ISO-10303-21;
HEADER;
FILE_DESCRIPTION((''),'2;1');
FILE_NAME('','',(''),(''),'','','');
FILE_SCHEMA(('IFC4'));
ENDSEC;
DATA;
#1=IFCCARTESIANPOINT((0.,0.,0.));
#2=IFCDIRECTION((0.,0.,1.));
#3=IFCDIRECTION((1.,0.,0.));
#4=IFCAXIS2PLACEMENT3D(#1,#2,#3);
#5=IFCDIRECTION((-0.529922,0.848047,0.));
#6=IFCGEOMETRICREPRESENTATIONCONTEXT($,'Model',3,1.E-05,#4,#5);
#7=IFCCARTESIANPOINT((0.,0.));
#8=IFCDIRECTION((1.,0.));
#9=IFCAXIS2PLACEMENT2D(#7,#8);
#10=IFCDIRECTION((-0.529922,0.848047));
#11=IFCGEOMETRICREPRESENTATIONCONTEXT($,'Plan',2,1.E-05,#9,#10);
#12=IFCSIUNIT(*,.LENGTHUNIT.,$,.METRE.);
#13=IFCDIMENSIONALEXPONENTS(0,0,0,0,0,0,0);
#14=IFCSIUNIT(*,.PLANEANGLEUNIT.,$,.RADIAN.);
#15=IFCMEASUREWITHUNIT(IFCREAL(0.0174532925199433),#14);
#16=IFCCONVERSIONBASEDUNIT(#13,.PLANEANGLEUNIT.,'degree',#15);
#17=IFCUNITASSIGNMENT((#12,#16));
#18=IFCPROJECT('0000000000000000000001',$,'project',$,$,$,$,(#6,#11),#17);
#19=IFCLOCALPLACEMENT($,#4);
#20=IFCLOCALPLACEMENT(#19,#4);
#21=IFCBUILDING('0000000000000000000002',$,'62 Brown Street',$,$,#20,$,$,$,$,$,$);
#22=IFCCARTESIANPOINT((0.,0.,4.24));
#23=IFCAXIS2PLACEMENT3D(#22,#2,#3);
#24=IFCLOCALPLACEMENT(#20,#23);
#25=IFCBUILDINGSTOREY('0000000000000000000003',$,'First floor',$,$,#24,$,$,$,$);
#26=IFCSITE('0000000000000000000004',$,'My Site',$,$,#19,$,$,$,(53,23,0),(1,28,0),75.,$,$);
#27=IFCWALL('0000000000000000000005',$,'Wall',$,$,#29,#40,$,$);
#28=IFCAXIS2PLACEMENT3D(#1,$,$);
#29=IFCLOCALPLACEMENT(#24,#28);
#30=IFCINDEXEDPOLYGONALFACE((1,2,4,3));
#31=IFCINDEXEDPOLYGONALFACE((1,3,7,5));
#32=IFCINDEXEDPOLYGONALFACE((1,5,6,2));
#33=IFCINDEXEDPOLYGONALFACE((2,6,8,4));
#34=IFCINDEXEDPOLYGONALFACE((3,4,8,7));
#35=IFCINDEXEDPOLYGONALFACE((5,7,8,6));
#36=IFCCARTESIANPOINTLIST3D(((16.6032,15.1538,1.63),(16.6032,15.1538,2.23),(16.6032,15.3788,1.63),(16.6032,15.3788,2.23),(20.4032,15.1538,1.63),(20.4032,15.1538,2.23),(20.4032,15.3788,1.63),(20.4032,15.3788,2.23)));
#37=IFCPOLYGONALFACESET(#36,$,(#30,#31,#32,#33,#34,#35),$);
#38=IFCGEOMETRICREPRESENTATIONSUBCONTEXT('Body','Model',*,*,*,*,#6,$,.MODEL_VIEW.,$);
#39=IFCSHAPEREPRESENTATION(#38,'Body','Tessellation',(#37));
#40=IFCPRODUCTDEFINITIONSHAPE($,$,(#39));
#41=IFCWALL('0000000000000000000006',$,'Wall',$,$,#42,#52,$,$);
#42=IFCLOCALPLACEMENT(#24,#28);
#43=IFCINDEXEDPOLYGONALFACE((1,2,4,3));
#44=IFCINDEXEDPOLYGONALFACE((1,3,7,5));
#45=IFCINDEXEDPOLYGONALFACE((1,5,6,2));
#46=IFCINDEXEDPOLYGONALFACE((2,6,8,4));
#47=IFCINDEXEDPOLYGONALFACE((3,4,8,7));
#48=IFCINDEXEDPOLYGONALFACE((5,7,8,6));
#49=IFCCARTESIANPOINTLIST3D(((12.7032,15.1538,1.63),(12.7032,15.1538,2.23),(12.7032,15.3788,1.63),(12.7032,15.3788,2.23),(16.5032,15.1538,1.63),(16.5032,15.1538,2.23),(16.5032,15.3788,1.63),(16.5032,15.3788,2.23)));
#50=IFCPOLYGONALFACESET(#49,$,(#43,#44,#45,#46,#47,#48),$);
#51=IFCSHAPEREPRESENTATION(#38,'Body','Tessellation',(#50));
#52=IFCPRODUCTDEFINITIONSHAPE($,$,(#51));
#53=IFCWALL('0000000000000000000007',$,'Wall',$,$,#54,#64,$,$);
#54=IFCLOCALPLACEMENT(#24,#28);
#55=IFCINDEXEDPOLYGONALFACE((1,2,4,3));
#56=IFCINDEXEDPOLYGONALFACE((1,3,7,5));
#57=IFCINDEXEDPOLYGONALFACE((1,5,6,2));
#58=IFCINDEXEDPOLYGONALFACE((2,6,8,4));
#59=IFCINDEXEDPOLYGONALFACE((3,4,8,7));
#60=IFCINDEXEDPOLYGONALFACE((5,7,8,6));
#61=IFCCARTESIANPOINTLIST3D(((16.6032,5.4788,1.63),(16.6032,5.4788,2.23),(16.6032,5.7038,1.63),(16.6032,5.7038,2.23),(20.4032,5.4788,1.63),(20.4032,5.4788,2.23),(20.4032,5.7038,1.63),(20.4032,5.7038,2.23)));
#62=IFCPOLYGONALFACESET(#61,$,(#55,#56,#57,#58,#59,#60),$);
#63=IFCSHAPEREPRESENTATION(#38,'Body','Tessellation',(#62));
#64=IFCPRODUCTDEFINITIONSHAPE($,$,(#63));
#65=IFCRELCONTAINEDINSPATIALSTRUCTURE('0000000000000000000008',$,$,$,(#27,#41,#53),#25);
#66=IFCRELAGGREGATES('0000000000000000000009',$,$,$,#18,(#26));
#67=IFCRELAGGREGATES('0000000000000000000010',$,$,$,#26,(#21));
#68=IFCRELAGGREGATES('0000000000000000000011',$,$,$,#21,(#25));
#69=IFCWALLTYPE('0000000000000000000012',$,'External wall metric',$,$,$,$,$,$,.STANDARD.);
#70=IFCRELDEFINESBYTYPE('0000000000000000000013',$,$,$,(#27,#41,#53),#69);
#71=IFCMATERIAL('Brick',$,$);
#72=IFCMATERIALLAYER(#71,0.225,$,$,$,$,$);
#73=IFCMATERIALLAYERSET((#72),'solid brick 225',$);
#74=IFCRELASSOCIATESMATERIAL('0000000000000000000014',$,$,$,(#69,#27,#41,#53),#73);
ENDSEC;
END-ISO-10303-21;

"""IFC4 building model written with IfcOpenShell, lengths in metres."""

from ifc_helpers import new_model, entity, si_unit, converted_unit, direction, frame, origin_with_axes, origin_2d_with_axis, place, context, subcontext, project, spatial, indexed_curve, outline, extrude, material, layer, layer_set, layer_usage, type_object, element, save


model = new_model("IFC4")

# Units and contexts
model_context = context("Model", 3, precision=1e-05, world=origin_with_axes(), true_north=direction((-0.529922, 0.848047, 0.0)))
plan_context = context("Plan", 2, precision=1e-05, world=origin_2d_with_axis(), true_north=direction((-0.529922, 0.848047)))
body_context = subcontext(model_context, "Body", "Model", "MODEL_VIEW")
ifc_project = project(units=[si_unit("LENGTHUNIT", "METRE"), converted_unit("PLANEANGLEUNIT", "degree", entity("IfcReal", 0.0174532925199433), si_unit("PLANEANGLEUNIT", "RADIAN"), dimensions=[0, 0, 0, 0, 0, 0, 0])], contexts=[model_context, plan_context])

# Site, building, storey
site_placement = place(None, origin_with_axes())
site = spatial("IfcSite", under=ifc_project, at=site_placement, Name="My Site", RefLatitude=(53, 23, 0), RefLongitude=(1, 28, 0), RefElevation=75.0)
building_placement = place(site_placement, origin_with_axes())
building = spatial("IfcBuilding", under=site, at=building_placement, Name="62 Brown Street")
storey_placement = place(building_placement, frame((0.0, 0.0, 4.24), z_axis=(0.0, 0.0, 1.0), x_axis=(1.0, 0.0, 0.0)))
storey = spatial("IfcBuildingStorey", under=building, at=storey_placement, Name="First floor")

# Walls
ifc_material_1 = material(Name="Brick")
ifc_layer_1 = layer(ifc_material_1, 0.225)
ifc_layer_set_1 = layer_set([ifc_layer_1], Name="solid brick 225")
ifc_layer_usage_1 = layer_usage(ifc_layer_set_1, "AXIS2", "POSITIVE", 0.0)
wall_type = type_object("IfcWallType", Name="External wall metric", PredefinedType="STANDARD", material=ifc_layer_set_1)
wall_1_placement = place(storey_placement, frame((20.4032, 15.3788, 1.63), z_axis=(0.0, 0.0, 1.0), x_axis=(-1.0, 0.0, 0.0)))
element("IfcWall", 1, at=wall_1_placement, inside=storey, type_object=wall_type, material=ifc_layer_usage_1, Name="Wall", context=body_context, shape_type="SweptSolid", body=[
    extrude(outline(indexed_curve([(0.0, 0.0), (0.0, 0.225), (3.8, 0.225), (3.8, 0.0), (0.0, 0.0)], self_intersect=False)), origin_with_axes(), (0.0, 0.0, 1.0), 0.6),
])
ifc_layer_usage_2 = layer_usage(ifc_layer_set_1, "AXIS2", "POSITIVE", 0.0)
wall_2_placement = place(storey_placement, frame((16.5032, 15.3788, 1.63), z_axis=(0.0, 0.0, 1.0), x_axis=(-1.0, 0.0, 0.0)))
element("IfcWall", 2, at=wall_2_placement, inside=storey, type_object=wall_type, material=ifc_layer_usage_2, Name="Wall", context=body_context, shape_type="SweptSolid", body=[
    extrude(outline(indexed_curve([(0.0, 0.0), (0.0, 0.225), (3.8, 0.225), (3.8, 0.0), (0.0, 0.0)], self_intersect=False)), origin_with_axes(), (0.0, 0.0, 1.0), 0.6),
])
ifc_layer_usage_3 = layer_usage(ifc_layer_set_1, "AXIS2", "POSITIVE", 0.0)
wall_3_placement = place(storey_placement, frame((16.6032, 5.4788, 1.63), z_axis=(0.0, 0.0, 1.0), x_axis=(1.0, 0.0, 0.0)))
element("IfcWall", 3, at=wall_3_placement, inside=storey, type_object=wall_type, material=ifc_layer_usage_3, Name="Wall", context=body_context, shape_type="SweptSolid", body=[
    extrude(outline(indexed_curve([(0.0, 0.0), (0.0, 0.225), (3.8, 0.225), (3.8, 0.0), (0.0, 0.0)], self_intersect=False)), origin_with_axes(), (0.0, 0.0, 1.0), 0.6),
])

save(model, "model.ifc")
